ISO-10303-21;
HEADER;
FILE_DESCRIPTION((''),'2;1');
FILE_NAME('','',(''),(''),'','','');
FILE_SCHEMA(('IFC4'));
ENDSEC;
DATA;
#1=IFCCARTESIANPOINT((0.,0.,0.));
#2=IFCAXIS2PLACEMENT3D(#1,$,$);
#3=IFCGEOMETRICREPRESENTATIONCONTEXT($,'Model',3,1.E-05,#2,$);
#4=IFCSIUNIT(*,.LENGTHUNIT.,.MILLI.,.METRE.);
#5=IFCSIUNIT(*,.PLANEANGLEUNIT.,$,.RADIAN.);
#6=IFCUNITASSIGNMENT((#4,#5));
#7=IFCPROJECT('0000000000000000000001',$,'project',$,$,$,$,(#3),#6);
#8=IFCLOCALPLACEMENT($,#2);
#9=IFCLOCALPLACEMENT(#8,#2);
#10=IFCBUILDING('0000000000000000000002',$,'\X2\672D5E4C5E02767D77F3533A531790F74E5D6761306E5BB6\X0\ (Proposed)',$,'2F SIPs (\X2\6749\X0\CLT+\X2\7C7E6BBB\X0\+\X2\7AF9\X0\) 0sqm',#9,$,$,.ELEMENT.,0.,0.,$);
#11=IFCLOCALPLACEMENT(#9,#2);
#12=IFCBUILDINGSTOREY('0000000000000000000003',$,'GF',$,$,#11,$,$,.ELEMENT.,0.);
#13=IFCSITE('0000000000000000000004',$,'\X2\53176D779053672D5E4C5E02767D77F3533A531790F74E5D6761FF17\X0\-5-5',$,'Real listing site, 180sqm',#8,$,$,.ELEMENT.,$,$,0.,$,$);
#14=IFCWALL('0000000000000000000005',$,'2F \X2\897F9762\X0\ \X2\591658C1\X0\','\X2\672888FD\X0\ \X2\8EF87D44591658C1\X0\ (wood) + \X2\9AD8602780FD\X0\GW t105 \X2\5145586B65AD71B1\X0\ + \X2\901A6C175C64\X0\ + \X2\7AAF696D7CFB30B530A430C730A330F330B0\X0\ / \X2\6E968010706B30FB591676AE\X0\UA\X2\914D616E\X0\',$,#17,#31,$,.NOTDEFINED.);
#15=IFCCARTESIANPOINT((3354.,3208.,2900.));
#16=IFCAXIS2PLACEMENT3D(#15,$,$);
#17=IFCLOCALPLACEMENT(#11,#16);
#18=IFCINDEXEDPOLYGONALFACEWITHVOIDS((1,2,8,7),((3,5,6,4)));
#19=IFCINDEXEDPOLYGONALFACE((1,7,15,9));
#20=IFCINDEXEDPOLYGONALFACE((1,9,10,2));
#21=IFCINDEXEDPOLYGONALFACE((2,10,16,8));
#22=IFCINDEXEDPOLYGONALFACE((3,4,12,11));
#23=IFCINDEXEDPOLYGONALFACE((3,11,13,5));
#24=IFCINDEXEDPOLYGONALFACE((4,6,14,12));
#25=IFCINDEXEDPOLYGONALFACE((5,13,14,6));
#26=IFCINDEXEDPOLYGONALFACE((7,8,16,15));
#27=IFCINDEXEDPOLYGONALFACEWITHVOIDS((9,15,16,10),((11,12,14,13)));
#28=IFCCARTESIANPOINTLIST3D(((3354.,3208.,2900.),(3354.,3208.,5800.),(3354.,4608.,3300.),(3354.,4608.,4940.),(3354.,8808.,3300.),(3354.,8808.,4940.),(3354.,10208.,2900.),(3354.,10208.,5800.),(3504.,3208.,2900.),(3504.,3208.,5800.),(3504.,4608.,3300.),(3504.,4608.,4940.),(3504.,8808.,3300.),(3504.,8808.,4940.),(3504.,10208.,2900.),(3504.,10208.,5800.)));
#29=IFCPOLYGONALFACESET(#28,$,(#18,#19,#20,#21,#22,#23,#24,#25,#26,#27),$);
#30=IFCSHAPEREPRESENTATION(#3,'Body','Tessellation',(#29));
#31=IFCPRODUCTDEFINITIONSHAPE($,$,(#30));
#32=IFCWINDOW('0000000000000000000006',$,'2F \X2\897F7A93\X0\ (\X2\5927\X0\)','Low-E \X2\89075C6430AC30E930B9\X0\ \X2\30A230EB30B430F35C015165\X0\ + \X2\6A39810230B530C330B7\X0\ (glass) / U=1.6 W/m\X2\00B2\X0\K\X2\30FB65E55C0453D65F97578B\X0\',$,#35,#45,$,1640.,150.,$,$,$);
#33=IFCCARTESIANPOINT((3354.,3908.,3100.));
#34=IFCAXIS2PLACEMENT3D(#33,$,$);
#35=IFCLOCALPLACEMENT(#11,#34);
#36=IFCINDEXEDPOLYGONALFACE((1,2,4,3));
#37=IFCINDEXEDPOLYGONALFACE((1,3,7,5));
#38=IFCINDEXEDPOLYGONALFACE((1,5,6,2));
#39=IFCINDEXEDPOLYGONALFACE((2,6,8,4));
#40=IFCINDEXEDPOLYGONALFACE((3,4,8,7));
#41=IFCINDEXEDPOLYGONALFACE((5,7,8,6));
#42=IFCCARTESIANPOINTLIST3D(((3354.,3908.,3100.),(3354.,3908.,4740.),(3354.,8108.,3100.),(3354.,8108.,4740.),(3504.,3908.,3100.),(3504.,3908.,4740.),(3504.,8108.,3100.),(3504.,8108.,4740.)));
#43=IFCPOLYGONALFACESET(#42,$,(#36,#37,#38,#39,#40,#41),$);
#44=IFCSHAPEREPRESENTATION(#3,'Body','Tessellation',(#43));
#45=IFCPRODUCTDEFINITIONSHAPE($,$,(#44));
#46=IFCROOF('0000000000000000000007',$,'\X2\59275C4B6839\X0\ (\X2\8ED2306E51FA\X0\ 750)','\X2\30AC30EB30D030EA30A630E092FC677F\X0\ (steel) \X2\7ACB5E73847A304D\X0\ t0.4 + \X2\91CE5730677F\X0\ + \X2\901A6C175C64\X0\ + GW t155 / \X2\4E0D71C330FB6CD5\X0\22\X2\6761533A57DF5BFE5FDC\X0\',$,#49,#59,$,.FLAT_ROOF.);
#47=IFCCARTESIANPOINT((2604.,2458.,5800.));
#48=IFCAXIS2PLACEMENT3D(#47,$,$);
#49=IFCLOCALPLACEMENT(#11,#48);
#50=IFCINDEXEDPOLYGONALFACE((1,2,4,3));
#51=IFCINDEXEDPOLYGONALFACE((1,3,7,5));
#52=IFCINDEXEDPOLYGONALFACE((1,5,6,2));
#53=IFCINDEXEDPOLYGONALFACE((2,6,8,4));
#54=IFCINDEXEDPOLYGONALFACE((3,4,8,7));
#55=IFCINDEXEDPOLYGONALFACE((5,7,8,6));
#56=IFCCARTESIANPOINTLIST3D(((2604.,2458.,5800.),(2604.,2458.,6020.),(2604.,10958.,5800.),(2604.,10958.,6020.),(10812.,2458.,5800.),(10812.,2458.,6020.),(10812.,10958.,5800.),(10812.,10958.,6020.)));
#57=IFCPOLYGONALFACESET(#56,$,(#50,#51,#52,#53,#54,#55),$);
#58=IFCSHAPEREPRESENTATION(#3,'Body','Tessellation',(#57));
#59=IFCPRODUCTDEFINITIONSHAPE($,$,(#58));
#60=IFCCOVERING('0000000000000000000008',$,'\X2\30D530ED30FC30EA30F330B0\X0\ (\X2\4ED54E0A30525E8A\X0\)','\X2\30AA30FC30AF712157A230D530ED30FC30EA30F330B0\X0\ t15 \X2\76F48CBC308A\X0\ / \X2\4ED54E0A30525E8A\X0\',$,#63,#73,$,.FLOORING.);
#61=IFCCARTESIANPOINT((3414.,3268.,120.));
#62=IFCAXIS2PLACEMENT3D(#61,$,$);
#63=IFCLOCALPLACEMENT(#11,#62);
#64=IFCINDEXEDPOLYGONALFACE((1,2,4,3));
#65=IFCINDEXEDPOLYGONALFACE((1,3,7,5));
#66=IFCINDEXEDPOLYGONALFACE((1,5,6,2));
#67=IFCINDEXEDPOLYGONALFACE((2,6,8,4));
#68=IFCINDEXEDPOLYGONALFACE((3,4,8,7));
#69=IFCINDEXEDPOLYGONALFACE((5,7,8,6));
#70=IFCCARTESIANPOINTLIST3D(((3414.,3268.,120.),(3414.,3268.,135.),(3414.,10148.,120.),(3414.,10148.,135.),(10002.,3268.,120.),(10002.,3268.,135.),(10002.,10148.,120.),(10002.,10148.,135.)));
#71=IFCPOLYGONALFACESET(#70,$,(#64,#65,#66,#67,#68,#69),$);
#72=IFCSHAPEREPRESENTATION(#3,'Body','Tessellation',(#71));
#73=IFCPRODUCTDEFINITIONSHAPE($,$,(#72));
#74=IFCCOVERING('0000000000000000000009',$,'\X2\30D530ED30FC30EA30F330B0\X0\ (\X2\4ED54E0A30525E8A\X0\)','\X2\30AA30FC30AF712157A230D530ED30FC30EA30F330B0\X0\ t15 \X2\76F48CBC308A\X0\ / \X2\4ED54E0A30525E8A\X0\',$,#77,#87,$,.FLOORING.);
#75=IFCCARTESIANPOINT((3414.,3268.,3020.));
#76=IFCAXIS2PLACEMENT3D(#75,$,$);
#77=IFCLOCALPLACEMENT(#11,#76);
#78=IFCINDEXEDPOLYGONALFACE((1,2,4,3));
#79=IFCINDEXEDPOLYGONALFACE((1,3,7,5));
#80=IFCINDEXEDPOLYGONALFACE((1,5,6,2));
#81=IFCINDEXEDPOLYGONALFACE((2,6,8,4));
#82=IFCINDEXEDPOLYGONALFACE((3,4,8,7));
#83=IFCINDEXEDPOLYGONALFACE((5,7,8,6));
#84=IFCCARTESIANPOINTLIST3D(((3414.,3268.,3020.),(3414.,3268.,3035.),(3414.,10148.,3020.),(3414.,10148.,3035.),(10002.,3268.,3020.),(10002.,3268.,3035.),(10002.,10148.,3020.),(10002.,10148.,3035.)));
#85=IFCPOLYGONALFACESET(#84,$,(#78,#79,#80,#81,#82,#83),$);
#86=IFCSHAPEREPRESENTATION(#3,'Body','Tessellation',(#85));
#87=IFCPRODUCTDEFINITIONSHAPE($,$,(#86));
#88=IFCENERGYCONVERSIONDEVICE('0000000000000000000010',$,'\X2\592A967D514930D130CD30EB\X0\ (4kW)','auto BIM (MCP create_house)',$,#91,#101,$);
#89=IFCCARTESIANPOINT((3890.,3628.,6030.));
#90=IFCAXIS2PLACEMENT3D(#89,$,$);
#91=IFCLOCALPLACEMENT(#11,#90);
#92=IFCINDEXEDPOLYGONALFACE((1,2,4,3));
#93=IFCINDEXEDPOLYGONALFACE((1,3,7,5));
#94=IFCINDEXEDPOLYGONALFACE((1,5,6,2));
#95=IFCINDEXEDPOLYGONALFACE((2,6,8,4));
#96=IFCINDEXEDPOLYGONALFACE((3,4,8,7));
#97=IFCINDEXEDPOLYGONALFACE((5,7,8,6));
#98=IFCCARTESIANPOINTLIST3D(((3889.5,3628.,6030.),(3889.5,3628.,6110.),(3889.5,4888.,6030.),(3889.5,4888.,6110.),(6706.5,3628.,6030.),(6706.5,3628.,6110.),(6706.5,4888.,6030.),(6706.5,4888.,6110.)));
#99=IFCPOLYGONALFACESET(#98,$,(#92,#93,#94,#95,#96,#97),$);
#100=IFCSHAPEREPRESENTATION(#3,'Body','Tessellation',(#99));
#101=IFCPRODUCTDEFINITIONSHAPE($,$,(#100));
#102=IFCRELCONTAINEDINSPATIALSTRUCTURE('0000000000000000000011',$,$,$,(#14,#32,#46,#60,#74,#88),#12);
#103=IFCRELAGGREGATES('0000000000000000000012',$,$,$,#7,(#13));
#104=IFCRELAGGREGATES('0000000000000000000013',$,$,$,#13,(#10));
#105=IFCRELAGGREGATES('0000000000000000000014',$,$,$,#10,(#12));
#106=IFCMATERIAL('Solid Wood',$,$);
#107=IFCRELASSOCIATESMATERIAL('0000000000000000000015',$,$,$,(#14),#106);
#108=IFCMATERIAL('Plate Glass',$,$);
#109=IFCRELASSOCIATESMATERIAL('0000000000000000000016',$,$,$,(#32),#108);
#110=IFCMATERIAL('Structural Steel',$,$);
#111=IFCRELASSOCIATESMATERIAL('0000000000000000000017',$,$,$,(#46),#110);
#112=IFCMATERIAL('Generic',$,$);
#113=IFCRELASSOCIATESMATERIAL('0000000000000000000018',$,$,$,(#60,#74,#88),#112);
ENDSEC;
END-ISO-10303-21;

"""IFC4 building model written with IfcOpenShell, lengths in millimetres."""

from ifc_helpers import new_model, si_unit, frame, frame_2d, origin, place, context, project, spatial, rectangle, extrude, material, element, fill, save


model = new_model("IFC4")

# Units and contexts
model_context = context("Model", 3, precision=1e-05, world=origin())
ifc_project = project(units=[si_unit("LENGTHUNIT", "METRE", prefix="MILLI"), si_unit("PLANEANGLEUNIT", "RADIAN")], contexts=[model_context])

# Site, building, storey
site_placement = place(None, origin())
site = spatial("IfcSite", under=ifc_project, at=site_placement, Name="北海道札幌市白石区北郷九条７-5-5", ObjectType="Real listing site, 180sqm", CompositionType="ELEMENT", RefElevation=0.0)
building_placement = place(site_placement, origin())
building = spatial("IfcBuilding", under=site, at=building_placement, Name="札幌市白石区北郷九条の家 (Proposed)", ObjectType="2F SIPs (杉CLT+籾殻+竹) 0sqm", CompositionType="ELEMENT", ElevationOfRefHeight=0.0, ElevationOfTerrain=0.0)
storey_placement = place(building_placement, origin())
storey = spatial("IfcBuildingStorey", under=building, at=storey_placement, Name="GF", CompositionType="ELEMENT", Elevation=0.0)

# Shared definitions
ifc_material_1 = material(Name="Solid Wood")

# Shared definitions
ifc_material_2 = material(Name="Plate Glass")

# Wall, opening, window
wall_1_placement = place(storey_placement, frame((3354.0, 3208.0, 2900.0)))
wall_1 = element("IfcWall", 1, at=wall_1_placement, inside=storey, material=ifc_material_1, Name="2F 西面 外壁", Description="木製 軸組外壁 (wood) + 高性能GW t105 充填断熱 + 通気層 + 窯業系サイディング / 準耐火・外皮UA配慮", PredefinedType="NOTDEFINED", context=model_context, shape_type="SweptSolid", body=[
    extrude(rectangle(XDim=150.0, YDim=7000.0, at=frame_2d((75.0, 3500.0))), frame((3354.0, 3208.0, 2900.0)), (0.0, 0.0, 1.0), 2900.0),
])
opening_1_placement = place(storey_placement, frame((3354.0, 3908.0, 3100.0)))
opening_1 = element("IfcOpeningElement", 2, at=opening_1_placement, cuts=wall_1, PredefinedType="NOTDEFINED", context=model_context, shape_type="SweptSolid", body=[
    extrude(rectangle(XDim=150.0, YDim=4200.0, at=frame_2d((75.0, 2100.0))), frame((3354.0, 3908.0, 3100.0)), (0.0, 0.0, 1.0), 1640.0),
])
window_1_placement = place(storey_placement, frame((3354.0, 3908.0, 3100.0)))
window_1 = element("IfcWindow", 3, at=window_1_placement, inside=storey, material=ifc_material_2, Name="2F 西窓 (大)", Description="Low-E 複層ガラス アルゴン封入 + 樹脂サッシ (glass) / U=1.6 W/m²K・日射取得型", OverallHeight=1640.0, OverallWidth=150.0, context=model_context, shape_type="SweptSolid", body=[
    extrude(rectangle(XDim=150.0, YDim=4200.0, at=frame_2d((75.0, 2100.0))), frame((3354.0, 3908.0, 3100.0)), (0.0, 0.0, 1.0), 1640.0),
])
fill(opening_1, window_1)

# Roof
ifc_material_3 = material(Name="Structural Steel")
roof_placement = place(storey_placement, frame((2604.0, 2458.0, 5800.0)))
element("IfcRoof", 4, at=roof_placement, inside=storey, material=ifc_material_3, Name="大屋根 (軒の出 750)", Description="ガルバリウム鋼板 (steel) 立平葺き t0.4 + 野地板 + 通気層 + GW t155 / 不燃・法22条区域対応", PredefinedType="FLAT_ROOF", context=model_context, shape_type="SweptSolid", body=[
    extrude(rectangle(XDim=8208.0, YDim=8500.0, at=frame_2d((4104.0, 4250.0))), frame((2604.0, 2458.0, 5800.0)), (0.0, 0.0, 1.0), 220.0),
])

# Coverings
ifc_material_4 = material(Name="Generic")
covering_1_placement = place(storey_placement, frame((3414.0, 3268.0, 120.0)))
element("IfcCovering", 5, at=covering_1_placement, inside=storey, material=ifc_material_4, Name="フローリング (仕上げ床)", Description="オーク無垢フローリング t15 直貼り / 仕上げ床", PredefinedType="FLOORING", context=model_context, shape_type="SweptSolid", body=[
    extrude(rectangle(XDim=6588.0, YDim=6880.0, at=frame_2d((3294.0, 3440.0))), frame((3414.0, 3268.0, 120.0)), (0.0, 0.0, 1.0), 15.0),
])
covering_2_placement = place(storey_placement, frame((3414.0, 3268.0, 3020.0)))
element("IfcCovering", 6, at=covering_2_placement, inside=storey, material=ifc_material_4, Name="フローリング (仕上げ床)", Description="オーク無垢フローリング t15 直貼り / 仕上げ床", PredefinedType="FLOORING", context=model_context, shape_type="SweptSolid", body=[
    extrude(rectangle(XDim=6588.0, YDim=6880.0, at=frame_2d((3294.0, 3440.0))), frame((3414.0, 3268.0, 3020.0)), (0.0, 0.0, 1.0), 15.0),
])

# Energy conversion device
energy_conversion_device_placement = place(storey_placement, frame((3890.0, 3628.0, 6030.0)))
element("IfcEnergyConversionDevice", 7, at=energy_conversion_device_placement, inside=storey, material=ifc_material_4, Name="太陽光パネル (4kW)", Description="auto BIM (MCP create_house)", context=model_context, shape_type="SweptSolid", body=[
    extrude(rectangle(XDim=2817.0, YDim=1260.0, at=frame_2d((1408.0, 630.0))), frame((3890.0, 3628.0, 6030.0)), (0.0, 0.0, 1.0), 80.0),
])

save(model, "model.ifc")
